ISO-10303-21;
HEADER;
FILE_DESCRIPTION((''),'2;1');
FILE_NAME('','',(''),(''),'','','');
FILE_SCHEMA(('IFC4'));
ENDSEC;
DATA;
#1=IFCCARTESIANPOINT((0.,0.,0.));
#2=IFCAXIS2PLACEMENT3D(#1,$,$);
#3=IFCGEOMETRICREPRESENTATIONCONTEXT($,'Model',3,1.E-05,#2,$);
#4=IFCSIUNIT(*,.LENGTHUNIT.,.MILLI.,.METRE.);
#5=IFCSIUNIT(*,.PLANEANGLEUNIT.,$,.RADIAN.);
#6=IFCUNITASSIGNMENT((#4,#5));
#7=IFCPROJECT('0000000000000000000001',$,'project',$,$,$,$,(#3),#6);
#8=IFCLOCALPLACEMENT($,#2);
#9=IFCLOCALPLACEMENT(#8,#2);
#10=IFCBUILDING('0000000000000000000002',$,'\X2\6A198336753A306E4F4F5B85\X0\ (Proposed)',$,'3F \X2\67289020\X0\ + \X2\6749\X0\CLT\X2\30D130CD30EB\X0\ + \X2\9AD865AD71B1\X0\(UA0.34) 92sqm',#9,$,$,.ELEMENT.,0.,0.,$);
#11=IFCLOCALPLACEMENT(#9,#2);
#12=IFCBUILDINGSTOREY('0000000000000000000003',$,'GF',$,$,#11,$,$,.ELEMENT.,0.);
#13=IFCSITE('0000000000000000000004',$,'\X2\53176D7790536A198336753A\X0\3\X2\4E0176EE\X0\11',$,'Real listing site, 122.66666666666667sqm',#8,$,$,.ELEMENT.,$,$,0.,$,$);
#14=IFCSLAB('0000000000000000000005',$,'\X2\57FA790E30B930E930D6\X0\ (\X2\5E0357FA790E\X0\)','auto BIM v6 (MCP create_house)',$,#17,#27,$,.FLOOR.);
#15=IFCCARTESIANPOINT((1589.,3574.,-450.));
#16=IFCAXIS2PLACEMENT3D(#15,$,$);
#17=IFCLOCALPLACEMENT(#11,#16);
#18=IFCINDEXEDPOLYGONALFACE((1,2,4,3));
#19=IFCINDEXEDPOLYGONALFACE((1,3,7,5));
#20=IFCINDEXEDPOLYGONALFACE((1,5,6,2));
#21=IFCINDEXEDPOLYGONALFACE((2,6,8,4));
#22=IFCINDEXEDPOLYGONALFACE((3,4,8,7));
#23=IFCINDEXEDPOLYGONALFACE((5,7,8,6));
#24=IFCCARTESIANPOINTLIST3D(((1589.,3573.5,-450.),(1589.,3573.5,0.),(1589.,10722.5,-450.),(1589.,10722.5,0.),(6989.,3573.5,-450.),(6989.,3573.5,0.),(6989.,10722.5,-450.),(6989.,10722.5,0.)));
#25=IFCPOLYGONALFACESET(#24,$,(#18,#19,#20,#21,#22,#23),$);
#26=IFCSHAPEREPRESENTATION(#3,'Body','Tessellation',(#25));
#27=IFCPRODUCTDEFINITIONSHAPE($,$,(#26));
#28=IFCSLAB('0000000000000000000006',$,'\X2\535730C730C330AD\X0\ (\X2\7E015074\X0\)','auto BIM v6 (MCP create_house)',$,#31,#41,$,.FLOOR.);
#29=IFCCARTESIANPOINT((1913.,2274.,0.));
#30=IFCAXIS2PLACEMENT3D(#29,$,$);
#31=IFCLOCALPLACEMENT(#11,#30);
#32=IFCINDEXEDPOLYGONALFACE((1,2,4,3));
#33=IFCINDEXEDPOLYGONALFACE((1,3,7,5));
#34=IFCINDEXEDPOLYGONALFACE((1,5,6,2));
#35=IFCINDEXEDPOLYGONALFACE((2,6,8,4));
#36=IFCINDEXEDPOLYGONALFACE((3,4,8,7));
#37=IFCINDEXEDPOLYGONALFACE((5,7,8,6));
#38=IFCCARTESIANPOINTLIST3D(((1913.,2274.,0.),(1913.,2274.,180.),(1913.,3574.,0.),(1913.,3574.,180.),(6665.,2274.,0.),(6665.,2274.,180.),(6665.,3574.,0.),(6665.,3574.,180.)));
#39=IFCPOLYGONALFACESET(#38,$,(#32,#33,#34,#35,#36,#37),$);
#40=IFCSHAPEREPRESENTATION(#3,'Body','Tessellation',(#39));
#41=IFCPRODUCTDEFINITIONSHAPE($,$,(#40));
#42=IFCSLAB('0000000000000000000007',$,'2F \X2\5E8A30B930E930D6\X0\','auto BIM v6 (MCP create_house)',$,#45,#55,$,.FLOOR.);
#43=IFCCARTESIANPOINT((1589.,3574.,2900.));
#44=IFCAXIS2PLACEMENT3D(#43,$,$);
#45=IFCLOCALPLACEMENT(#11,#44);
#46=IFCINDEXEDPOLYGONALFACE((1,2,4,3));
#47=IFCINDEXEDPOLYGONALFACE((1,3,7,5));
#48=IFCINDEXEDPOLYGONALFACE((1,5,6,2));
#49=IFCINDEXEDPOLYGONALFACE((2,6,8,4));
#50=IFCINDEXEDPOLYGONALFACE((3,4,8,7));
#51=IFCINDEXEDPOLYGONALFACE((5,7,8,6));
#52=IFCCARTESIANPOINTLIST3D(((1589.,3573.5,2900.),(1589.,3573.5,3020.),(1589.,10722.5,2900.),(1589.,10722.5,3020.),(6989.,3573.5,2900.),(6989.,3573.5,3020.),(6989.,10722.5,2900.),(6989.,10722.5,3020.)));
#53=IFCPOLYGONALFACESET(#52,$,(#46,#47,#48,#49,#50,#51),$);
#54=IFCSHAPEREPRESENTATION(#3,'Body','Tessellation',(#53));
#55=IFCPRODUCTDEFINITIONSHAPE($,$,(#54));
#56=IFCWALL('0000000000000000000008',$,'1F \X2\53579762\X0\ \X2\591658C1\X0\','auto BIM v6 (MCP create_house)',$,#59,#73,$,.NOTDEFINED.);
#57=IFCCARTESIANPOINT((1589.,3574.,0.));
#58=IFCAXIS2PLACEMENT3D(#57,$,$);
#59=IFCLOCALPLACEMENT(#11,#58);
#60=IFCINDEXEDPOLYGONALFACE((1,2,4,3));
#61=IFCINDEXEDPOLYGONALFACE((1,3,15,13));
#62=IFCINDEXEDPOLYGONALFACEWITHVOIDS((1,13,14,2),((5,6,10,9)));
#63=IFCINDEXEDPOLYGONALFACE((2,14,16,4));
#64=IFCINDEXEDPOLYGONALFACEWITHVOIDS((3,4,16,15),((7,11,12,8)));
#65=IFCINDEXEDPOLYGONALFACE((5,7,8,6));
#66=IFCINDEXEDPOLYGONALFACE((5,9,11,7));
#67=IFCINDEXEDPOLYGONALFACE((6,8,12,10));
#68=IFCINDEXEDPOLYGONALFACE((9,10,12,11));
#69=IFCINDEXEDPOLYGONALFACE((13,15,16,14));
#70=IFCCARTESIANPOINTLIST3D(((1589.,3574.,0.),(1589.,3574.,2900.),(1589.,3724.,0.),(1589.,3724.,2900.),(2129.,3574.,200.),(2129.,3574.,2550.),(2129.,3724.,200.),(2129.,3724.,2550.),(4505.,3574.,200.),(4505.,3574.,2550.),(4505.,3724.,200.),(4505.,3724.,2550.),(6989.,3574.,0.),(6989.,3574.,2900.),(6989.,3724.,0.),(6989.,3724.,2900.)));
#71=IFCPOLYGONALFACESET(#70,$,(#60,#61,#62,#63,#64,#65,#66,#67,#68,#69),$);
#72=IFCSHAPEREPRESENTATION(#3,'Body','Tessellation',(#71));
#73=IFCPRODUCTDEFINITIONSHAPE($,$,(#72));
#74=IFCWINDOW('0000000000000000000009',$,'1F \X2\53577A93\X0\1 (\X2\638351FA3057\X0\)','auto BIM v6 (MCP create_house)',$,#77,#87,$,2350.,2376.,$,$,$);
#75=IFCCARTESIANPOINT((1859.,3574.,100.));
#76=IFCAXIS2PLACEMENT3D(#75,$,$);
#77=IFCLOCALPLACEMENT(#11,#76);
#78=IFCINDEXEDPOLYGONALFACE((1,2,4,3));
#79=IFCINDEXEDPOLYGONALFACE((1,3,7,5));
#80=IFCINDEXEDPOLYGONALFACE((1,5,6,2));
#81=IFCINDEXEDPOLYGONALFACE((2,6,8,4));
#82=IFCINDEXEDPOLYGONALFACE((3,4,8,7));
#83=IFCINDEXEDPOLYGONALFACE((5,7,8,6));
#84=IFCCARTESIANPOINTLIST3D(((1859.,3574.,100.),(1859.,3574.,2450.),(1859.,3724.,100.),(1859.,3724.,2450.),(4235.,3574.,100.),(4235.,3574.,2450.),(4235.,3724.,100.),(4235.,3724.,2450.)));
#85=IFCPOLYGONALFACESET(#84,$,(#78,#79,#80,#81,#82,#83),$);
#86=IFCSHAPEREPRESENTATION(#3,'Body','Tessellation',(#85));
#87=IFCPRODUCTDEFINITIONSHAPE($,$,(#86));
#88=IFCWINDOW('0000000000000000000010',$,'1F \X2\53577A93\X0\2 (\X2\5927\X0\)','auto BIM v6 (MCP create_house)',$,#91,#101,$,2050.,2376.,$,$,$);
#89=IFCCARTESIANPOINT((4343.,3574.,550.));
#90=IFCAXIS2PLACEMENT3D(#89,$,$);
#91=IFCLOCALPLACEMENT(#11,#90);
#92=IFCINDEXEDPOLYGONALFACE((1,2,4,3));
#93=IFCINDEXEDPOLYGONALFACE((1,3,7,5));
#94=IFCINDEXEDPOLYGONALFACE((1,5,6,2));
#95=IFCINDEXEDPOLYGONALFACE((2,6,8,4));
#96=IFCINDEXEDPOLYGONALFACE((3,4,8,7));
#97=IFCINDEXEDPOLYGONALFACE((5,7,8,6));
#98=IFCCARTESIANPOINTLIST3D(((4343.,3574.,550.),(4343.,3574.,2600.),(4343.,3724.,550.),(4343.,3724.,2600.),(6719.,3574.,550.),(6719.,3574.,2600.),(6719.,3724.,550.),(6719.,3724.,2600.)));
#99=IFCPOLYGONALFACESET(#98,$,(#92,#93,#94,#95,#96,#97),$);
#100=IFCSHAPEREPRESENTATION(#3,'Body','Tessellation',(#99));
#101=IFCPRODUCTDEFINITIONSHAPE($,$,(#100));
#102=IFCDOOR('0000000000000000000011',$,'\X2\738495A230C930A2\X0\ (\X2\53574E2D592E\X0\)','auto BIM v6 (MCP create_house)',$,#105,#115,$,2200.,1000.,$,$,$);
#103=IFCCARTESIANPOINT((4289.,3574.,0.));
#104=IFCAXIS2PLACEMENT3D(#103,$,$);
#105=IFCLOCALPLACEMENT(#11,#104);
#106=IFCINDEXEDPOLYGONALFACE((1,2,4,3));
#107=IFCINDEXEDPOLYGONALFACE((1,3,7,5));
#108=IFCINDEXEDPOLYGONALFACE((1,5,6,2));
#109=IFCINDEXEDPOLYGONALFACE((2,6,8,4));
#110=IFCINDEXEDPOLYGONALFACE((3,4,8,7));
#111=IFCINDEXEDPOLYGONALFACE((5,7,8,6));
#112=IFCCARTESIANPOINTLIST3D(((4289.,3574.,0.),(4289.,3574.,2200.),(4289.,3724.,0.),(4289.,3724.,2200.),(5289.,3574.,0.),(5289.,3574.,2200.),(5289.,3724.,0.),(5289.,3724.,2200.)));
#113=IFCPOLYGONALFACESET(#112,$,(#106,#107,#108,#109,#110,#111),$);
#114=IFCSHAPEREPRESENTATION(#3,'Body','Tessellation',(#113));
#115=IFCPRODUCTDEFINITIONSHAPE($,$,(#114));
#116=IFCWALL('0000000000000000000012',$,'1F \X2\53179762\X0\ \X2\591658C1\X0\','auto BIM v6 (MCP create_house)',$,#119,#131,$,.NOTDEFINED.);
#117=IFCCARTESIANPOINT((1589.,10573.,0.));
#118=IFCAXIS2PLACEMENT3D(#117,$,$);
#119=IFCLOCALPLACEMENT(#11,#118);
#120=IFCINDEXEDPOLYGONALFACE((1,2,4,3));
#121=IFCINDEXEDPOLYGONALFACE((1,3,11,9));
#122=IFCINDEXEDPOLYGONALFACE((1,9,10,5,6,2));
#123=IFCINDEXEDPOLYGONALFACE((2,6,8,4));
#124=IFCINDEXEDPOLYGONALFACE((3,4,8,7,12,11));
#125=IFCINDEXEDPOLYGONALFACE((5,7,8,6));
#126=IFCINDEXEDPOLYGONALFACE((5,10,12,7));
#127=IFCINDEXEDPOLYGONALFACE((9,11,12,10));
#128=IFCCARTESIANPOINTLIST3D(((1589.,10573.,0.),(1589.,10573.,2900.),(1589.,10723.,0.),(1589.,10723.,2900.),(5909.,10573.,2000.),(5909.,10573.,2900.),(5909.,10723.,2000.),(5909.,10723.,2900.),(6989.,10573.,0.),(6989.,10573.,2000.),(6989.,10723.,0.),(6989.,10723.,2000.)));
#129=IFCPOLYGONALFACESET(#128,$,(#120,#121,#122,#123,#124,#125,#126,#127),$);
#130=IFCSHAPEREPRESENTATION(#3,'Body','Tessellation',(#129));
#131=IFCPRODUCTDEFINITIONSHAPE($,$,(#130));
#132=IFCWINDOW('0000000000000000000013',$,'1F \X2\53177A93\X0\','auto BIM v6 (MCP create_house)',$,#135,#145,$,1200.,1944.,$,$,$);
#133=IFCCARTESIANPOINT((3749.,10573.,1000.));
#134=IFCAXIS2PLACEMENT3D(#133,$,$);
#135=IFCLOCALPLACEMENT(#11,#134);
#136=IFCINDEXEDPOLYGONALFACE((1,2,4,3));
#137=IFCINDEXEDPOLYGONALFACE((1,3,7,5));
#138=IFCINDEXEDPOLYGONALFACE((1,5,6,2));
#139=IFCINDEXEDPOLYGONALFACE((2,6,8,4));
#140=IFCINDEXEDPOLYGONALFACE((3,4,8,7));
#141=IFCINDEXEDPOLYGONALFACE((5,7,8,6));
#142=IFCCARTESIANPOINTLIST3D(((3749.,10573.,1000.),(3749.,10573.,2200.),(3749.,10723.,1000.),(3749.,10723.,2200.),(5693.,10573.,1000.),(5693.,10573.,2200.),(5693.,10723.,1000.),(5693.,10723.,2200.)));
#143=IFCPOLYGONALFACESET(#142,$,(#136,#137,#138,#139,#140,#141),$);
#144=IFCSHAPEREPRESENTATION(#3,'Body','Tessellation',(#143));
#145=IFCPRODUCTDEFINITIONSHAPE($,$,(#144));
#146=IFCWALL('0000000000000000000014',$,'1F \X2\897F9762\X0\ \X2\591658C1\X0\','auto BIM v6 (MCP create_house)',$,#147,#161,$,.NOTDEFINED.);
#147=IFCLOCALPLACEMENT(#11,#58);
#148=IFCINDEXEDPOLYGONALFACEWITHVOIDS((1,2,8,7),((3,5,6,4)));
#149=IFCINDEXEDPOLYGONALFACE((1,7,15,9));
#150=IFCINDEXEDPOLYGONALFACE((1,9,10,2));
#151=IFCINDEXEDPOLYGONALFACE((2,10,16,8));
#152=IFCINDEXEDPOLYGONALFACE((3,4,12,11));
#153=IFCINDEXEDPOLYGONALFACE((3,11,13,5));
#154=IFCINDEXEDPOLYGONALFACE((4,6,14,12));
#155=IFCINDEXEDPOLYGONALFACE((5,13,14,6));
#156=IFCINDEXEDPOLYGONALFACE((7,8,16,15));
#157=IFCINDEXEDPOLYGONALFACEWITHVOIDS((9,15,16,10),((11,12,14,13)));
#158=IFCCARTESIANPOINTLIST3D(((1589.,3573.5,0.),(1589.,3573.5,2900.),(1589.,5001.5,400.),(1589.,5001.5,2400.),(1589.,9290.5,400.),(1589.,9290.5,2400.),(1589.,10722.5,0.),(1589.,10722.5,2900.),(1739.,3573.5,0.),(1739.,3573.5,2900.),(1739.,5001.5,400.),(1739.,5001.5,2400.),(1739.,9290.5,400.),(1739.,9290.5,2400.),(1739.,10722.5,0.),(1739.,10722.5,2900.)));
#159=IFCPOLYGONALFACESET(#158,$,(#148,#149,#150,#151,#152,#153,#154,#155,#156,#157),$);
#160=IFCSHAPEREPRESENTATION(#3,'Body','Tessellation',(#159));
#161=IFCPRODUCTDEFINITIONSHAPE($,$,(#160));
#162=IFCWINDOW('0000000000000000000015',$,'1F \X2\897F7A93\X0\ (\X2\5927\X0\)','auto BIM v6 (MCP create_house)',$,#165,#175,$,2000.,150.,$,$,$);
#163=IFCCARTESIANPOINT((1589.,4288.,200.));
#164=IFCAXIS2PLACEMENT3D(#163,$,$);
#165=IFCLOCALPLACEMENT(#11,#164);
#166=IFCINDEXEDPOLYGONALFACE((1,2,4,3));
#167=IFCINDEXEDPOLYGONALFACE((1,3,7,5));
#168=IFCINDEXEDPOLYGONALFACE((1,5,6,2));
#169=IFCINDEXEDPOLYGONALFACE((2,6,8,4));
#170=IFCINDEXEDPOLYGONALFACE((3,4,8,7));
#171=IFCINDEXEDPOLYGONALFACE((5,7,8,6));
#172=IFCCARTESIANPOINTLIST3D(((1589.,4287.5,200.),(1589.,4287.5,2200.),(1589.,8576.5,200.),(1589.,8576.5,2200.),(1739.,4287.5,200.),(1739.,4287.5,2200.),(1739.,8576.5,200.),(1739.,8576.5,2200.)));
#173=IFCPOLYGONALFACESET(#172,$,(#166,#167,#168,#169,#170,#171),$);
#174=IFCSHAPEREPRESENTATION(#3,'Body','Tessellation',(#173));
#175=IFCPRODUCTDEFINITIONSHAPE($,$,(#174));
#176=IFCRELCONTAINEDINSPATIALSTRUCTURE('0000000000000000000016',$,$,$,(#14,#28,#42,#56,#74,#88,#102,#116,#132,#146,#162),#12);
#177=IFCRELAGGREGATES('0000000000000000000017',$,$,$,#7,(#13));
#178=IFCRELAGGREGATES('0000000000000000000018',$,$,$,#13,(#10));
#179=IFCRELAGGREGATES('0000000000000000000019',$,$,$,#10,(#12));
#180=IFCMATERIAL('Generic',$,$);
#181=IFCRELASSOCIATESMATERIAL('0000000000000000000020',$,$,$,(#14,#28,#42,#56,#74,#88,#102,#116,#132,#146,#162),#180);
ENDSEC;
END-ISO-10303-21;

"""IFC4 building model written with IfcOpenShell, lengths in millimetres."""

from ifc_helpers import new_model, si_unit, frame, frame_2d, origin, place, context, project, spatial, rectangle, extrude, material, element, fill, save


model = new_model("IFC4")

# Units and contexts
model_context = context("Model", 3, precision=1e-05, world=origin())
ifc_project = project(units=[si_unit("LENGTHUNIT", "METRE", prefix="MILLI"), si_unit("PLANEANGLEUNIT", "RADIAN")], contexts=[model_context])

# Site, building, storey
site_placement = place(None, origin())
site = spatial("IfcSite", under=ifc_project, at=site_placement, Name="北海道標茶町3丁目11", ObjectType="Real listing site, 122.66666666666667sqm", CompositionType="ELEMENT", RefElevation=0.0)
building_placement = place(site_placement, origin())
building = spatial("IfcBuilding", under=site, at=building_placement, Name="標茶町の住宅 (Proposed)", ObjectType="3F 木造 + 杉CLTパネル + 高断熱(UA0.34) 92sqm", CompositionType="ELEMENT", ElevationOfRefHeight=0.0, ElevationOfTerrain=0.0)
storey_placement = place(building_placement, origin())
storey = spatial("IfcBuildingStorey", under=building, at=storey_placement, Name="GF", CompositionType="ELEMENT", Elevation=0.0)

# Slabs
ifc_material = material(Name="Generic")
slab_1_placement = place(storey_placement, frame((1589.0, 3574.0, -450.0)))
element("IfcSlab", 1, at=slab_1_placement, inside=storey, material=ifc_material, Name="基礎スラブ (布基礎)", Description="auto BIM v6 (MCP create_house)", PredefinedType="FLOOR", context=model_context, shape_type="SweptSolid", body=[
    extrude(rectangle(XDim=5400.0, YDim=7149.0, at=frame_2d((2700.0, 3574.0))), frame((1589.0, 3574.0, -450.0)), (0.0, 0.0, 1.0), 450.0),
])
slab_2_placement = place(storey_placement, frame((1913.0, 2274.0, 0.0)))
element("IfcSlab", 2, at=slab_2_placement, inside=storey, material=ifc_material, Name="南デッキ (縁側)", Description="auto BIM v6 (MCP create_house)", PredefinedType="FLOOR", context=model_context, shape_type="SweptSolid", body=[
    extrude(rectangle(XDim=4752.0, YDim=1300.0, at=frame_2d((2376.0, 650.0))), frame((1913.0, 2274.0, 0.0)), (0.0, 0.0, 1.0), 180.0),
])
slab_3_placement = place(storey_placement, frame((1589.0, 3574.0, 2900.0)))
element("IfcSlab", 3, at=slab_3_placement, inside=storey, material=ifc_material, Name="2F 床スラブ", Description="auto BIM v6 (MCP create_house)", PredefinedType="FLOOR", context=model_context, shape_type="SweptSolid", body=[
    extrude(rectangle(XDim=5400.0, YDim=7149.0, at=frame_2d((2700.0, 3574.0))), frame((1589.0, 3574.0, 2900.0)), (0.0, 0.0, 1.0), 120.0),
])

# Wall, openings, windows, door
wall_1_placement = place(storey_placement, frame((1589.0, 3574.0, 0.0)))
wall_1 = element("IfcWall", 4, at=wall_1_placement, inside=storey, material=ifc_material, Name="1F 南面 外壁", Description="auto BIM v6 (MCP create_house)", PredefinedType="NOTDEFINED", context=model_context, shape_type="SweptSolid", body=[
    extrude(rectangle(XDim=5400.0, YDim=150.0, at=frame_2d((2700.0, 75.0))), frame((1589.0, 3574.0, 0.0)), (0.0, 0.0, 1.0), 2900.0),
])
opening_1_placement = place(storey_placement, frame((1859.0, 3574.0, 100.0)))
opening_1 = element("IfcOpeningElement", 5, at=opening_1_placement, cuts=wall_1, PredefinedType="NOTDEFINED", context=model_context, shape_type="SweptSolid", body=[
    extrude(rectangle(XDim=2376.0, YDim=150.0, at=frame_2d((1188.0, 75.0))), frame((1859.0, 3574.0, 100.0)), (0.0, 0.0, 1.0), 2350.0),
])
opening_2_placement = place(storey_placement, frame((4343.0, 3574.0, 550.0)))
opening_2 = element("IfcOpeningElement", 6, at=opening_2_placement, cuts=wall_1, PredefinedType="NOTDEFINED", context=model_context, shape_type="SweptSolid", body=[
    extrude(rectangle(XDim=2376.0, YDim=150.0, at=frame_2d((1188.0, 75.0))), frame((4343.0, 3574.0, 550.0)), (0.0, 0.0, 1.0), 2050.0),
])
opening_3_placement = place(storey_placement, frame((4289.0, 3574.0, 0.0)))
opening_3 = element("IfcOpeningElement", 7, at=opening_3_placement, cuts=wall_1, PredefinedType="NOTDEFINED", context=model_context, shape_type="SweptSolid", body=[
    extrude(rectangle(XDim=1000.0, YDim=150.0, at=frame_2d((500.0, 75.0))), frame((4289.0, 3574.0, 0.0)), (0.0, 0.0, 1.0), 2200.0),
])
window_1_placement = place(storey_placement, frame((1859.0, 3574.0, 100.0)))
window_1 = element("IfcWindow", 8, at=window_1_placement, inside=storey, material=ifc_material, Name="1F 南窓1 (掃出し)", Description="auto BIM v6 (MCP create_house)", OverallHeight=2350.0, OverallWidth=2376.0, context=model_context, shape_type="SweptSolid", body=[
    extrude(rectangle(XDim=2376.0, YDim=150.0, at=frame_2d((1188.0, 75.0))), frame((1859.0, 3574.0, 100.0)), (0.0, 0.0, 1.0), 2350.0),
])
fill(opening_1, window_1)
window_2_placement = place(storey_placement, frame((4343.0, 3574.0, 550.0)))
window_2 = element("IfcWindow", 9, at=window_2_placement, inside=storey, material=ifc_material, Name="1F 南窓2 (大)", Description="auto BIM v6 (MCP create_house)", OverallHeight=2050.0, OverallWidth=2376.0, context=model_context, shape_type="SweptSolid", body=[
    extrude(rectangle(XDim=2376.0, YDim=150.0, at=frame_2d((1188.0, 75.0))), frame((4343.0, 3574.0, 550.0)), (0.0, 0.0, 1.0), 2050.0),
])
fill(opening_2, window_2)
door_placement = place(storey_placement, frame((4289.0, 3574.0, 0.0)))
door = element("IfcDoor", 10, at=door_placement, inside=storey, material=ifc_material, Name="玄関ドア (南中央)", Description="auto BIM v6 (MCP create_house)", OverallHeight=2200.0, OverallWidth=1000.0, context=model_context, shape_type="SweptSolid", body=[
    extrude(rectangle(XDim=1000.0, YDim=150.0, at=frame_2d((500.0, 75.0))), frame((4289.0, 3574.0, 0.0)), (0.0, 0.0, 1.0), 2200.0),
])
fill(opening_3, door)

# Walls, openings, windows
wall_2_placement = place(storey_placement, frame((1589.0, 10573.0, 0.0)))
wall_2 = element("IfcWall", 11, at=wall_2_placement, inside=storey, material=ifc_material, Name="1F 北面 外壁", Description="auto BIM v6 (MCP create_house)", PredefinedType="NOTDEFINED", context=model_context, shape_type="SweptSolid", body=[
    extrude(rectangle(XDim=5400.0, YDim=150.0, at=frame_2d((2700.0, 75.0))), frame((1589.0, 10573.0, 0.0)), (0.0, 0.0, 1.0), 2900.0),
])
opening_4_placement = place(storey_placement, frame((3749.0, 10573.0, 1000.0)))
opening_4 = element("IfcOpeningElement", 12, at=opening_4_placement, cuts=wall_2, PredefinedType="NOTDEFINED", context=model_context, shape_type="SweptSolid", body=[
    extrude(rectangle(XDim=1944.0, YDim=150.0, at=frame_2d((972.0, 75.0))), frame((3749.0, 10573.0, 1000.0)), (0.0, 0.0, 1.0), 1200.0),
])
window_3_placement = place(storey_placement, frame((3749.0, 10573.0, 1000.0)))
window_3 = element("IfcWindow", 13, at=window_3_placement, inside=storey, material=ifc_material, Name="1F 北窓", Description="auto BIM v6 (MCP create_house)", OverallHeight=1200.0, OverallWidth=1944.0, context=model_context, shape_type="SweptSolid", body=[
    extrude(rectangle(XDim=1944.0, YDim=150.0, at=frame_2d((972.0, 75.0))), frame((3749.0, 10573.0, 1000.0)), (0.0, 0.0, 1.0), 1200.0),
])
fill(opening_4, window_3)
wall_3_placement = place(storey_placement, frame((1589.0, 3574.0, 0.0)))
wall_3 = element("IfcWall", 14, at=wall_3_placement, inside=storey, material=ifc_material, Name="1F 西面 外壁", Description="auto BIM v6 (MCP create_house)", PredefinedType="NOTDEFINED", context=model_context, shape_type="SweptSolid", body=[
    extrude(rectangle(XDim=150.0, YDim=7149.0, at=frame_2d((75.0, 3574.0))), frame((1589.0, 3574.0, 0.0)), (0.0, 0.0, 1.0), 2900.0),
])
opening_5_placement = place(storey_placement, frame((1589.0, 4288.0, 200.0)))
opening_5 = element("IfcOpeningElement", 15, at=opening_5_placement, cuts=wall_3, PredefinedType="NOTDEFINED", context=model_context, shape_type="SweptSolid", body=[
    extrude(rectangle(XDim=150.0, YDim=4289.0, at=frame_2d((75.0, 2144.0))), frame((1589.0, 4288.0, 200.0)), (0.0, 0.0, 1.0), 2000.0),
])
window_4_placement = place(storey_placement, frame((1589.0, 4288.0, 200.0)))
window_4 = element("IfcWindow", 16, at=window_4_placement, inside=storey, material=ifc_material, Name="1F 西窓 (大)", Description="auto BIM v6 (MCP create_house)", OverallHeight=2000.0, OverallWidth=150.0, context=model_context, shape_type="SweptSolid", body=[
    extrude(rectangle(XDim=150.0, YDim=4289.0, at=frame_2d((75.0, 2144.0))), frame((1589.0, 4288.0, 200.0)), (0.0, 0.0, 1.0), 2000.0),
])
fill(opening_5, window_4)

save(model, "model.ifc")
